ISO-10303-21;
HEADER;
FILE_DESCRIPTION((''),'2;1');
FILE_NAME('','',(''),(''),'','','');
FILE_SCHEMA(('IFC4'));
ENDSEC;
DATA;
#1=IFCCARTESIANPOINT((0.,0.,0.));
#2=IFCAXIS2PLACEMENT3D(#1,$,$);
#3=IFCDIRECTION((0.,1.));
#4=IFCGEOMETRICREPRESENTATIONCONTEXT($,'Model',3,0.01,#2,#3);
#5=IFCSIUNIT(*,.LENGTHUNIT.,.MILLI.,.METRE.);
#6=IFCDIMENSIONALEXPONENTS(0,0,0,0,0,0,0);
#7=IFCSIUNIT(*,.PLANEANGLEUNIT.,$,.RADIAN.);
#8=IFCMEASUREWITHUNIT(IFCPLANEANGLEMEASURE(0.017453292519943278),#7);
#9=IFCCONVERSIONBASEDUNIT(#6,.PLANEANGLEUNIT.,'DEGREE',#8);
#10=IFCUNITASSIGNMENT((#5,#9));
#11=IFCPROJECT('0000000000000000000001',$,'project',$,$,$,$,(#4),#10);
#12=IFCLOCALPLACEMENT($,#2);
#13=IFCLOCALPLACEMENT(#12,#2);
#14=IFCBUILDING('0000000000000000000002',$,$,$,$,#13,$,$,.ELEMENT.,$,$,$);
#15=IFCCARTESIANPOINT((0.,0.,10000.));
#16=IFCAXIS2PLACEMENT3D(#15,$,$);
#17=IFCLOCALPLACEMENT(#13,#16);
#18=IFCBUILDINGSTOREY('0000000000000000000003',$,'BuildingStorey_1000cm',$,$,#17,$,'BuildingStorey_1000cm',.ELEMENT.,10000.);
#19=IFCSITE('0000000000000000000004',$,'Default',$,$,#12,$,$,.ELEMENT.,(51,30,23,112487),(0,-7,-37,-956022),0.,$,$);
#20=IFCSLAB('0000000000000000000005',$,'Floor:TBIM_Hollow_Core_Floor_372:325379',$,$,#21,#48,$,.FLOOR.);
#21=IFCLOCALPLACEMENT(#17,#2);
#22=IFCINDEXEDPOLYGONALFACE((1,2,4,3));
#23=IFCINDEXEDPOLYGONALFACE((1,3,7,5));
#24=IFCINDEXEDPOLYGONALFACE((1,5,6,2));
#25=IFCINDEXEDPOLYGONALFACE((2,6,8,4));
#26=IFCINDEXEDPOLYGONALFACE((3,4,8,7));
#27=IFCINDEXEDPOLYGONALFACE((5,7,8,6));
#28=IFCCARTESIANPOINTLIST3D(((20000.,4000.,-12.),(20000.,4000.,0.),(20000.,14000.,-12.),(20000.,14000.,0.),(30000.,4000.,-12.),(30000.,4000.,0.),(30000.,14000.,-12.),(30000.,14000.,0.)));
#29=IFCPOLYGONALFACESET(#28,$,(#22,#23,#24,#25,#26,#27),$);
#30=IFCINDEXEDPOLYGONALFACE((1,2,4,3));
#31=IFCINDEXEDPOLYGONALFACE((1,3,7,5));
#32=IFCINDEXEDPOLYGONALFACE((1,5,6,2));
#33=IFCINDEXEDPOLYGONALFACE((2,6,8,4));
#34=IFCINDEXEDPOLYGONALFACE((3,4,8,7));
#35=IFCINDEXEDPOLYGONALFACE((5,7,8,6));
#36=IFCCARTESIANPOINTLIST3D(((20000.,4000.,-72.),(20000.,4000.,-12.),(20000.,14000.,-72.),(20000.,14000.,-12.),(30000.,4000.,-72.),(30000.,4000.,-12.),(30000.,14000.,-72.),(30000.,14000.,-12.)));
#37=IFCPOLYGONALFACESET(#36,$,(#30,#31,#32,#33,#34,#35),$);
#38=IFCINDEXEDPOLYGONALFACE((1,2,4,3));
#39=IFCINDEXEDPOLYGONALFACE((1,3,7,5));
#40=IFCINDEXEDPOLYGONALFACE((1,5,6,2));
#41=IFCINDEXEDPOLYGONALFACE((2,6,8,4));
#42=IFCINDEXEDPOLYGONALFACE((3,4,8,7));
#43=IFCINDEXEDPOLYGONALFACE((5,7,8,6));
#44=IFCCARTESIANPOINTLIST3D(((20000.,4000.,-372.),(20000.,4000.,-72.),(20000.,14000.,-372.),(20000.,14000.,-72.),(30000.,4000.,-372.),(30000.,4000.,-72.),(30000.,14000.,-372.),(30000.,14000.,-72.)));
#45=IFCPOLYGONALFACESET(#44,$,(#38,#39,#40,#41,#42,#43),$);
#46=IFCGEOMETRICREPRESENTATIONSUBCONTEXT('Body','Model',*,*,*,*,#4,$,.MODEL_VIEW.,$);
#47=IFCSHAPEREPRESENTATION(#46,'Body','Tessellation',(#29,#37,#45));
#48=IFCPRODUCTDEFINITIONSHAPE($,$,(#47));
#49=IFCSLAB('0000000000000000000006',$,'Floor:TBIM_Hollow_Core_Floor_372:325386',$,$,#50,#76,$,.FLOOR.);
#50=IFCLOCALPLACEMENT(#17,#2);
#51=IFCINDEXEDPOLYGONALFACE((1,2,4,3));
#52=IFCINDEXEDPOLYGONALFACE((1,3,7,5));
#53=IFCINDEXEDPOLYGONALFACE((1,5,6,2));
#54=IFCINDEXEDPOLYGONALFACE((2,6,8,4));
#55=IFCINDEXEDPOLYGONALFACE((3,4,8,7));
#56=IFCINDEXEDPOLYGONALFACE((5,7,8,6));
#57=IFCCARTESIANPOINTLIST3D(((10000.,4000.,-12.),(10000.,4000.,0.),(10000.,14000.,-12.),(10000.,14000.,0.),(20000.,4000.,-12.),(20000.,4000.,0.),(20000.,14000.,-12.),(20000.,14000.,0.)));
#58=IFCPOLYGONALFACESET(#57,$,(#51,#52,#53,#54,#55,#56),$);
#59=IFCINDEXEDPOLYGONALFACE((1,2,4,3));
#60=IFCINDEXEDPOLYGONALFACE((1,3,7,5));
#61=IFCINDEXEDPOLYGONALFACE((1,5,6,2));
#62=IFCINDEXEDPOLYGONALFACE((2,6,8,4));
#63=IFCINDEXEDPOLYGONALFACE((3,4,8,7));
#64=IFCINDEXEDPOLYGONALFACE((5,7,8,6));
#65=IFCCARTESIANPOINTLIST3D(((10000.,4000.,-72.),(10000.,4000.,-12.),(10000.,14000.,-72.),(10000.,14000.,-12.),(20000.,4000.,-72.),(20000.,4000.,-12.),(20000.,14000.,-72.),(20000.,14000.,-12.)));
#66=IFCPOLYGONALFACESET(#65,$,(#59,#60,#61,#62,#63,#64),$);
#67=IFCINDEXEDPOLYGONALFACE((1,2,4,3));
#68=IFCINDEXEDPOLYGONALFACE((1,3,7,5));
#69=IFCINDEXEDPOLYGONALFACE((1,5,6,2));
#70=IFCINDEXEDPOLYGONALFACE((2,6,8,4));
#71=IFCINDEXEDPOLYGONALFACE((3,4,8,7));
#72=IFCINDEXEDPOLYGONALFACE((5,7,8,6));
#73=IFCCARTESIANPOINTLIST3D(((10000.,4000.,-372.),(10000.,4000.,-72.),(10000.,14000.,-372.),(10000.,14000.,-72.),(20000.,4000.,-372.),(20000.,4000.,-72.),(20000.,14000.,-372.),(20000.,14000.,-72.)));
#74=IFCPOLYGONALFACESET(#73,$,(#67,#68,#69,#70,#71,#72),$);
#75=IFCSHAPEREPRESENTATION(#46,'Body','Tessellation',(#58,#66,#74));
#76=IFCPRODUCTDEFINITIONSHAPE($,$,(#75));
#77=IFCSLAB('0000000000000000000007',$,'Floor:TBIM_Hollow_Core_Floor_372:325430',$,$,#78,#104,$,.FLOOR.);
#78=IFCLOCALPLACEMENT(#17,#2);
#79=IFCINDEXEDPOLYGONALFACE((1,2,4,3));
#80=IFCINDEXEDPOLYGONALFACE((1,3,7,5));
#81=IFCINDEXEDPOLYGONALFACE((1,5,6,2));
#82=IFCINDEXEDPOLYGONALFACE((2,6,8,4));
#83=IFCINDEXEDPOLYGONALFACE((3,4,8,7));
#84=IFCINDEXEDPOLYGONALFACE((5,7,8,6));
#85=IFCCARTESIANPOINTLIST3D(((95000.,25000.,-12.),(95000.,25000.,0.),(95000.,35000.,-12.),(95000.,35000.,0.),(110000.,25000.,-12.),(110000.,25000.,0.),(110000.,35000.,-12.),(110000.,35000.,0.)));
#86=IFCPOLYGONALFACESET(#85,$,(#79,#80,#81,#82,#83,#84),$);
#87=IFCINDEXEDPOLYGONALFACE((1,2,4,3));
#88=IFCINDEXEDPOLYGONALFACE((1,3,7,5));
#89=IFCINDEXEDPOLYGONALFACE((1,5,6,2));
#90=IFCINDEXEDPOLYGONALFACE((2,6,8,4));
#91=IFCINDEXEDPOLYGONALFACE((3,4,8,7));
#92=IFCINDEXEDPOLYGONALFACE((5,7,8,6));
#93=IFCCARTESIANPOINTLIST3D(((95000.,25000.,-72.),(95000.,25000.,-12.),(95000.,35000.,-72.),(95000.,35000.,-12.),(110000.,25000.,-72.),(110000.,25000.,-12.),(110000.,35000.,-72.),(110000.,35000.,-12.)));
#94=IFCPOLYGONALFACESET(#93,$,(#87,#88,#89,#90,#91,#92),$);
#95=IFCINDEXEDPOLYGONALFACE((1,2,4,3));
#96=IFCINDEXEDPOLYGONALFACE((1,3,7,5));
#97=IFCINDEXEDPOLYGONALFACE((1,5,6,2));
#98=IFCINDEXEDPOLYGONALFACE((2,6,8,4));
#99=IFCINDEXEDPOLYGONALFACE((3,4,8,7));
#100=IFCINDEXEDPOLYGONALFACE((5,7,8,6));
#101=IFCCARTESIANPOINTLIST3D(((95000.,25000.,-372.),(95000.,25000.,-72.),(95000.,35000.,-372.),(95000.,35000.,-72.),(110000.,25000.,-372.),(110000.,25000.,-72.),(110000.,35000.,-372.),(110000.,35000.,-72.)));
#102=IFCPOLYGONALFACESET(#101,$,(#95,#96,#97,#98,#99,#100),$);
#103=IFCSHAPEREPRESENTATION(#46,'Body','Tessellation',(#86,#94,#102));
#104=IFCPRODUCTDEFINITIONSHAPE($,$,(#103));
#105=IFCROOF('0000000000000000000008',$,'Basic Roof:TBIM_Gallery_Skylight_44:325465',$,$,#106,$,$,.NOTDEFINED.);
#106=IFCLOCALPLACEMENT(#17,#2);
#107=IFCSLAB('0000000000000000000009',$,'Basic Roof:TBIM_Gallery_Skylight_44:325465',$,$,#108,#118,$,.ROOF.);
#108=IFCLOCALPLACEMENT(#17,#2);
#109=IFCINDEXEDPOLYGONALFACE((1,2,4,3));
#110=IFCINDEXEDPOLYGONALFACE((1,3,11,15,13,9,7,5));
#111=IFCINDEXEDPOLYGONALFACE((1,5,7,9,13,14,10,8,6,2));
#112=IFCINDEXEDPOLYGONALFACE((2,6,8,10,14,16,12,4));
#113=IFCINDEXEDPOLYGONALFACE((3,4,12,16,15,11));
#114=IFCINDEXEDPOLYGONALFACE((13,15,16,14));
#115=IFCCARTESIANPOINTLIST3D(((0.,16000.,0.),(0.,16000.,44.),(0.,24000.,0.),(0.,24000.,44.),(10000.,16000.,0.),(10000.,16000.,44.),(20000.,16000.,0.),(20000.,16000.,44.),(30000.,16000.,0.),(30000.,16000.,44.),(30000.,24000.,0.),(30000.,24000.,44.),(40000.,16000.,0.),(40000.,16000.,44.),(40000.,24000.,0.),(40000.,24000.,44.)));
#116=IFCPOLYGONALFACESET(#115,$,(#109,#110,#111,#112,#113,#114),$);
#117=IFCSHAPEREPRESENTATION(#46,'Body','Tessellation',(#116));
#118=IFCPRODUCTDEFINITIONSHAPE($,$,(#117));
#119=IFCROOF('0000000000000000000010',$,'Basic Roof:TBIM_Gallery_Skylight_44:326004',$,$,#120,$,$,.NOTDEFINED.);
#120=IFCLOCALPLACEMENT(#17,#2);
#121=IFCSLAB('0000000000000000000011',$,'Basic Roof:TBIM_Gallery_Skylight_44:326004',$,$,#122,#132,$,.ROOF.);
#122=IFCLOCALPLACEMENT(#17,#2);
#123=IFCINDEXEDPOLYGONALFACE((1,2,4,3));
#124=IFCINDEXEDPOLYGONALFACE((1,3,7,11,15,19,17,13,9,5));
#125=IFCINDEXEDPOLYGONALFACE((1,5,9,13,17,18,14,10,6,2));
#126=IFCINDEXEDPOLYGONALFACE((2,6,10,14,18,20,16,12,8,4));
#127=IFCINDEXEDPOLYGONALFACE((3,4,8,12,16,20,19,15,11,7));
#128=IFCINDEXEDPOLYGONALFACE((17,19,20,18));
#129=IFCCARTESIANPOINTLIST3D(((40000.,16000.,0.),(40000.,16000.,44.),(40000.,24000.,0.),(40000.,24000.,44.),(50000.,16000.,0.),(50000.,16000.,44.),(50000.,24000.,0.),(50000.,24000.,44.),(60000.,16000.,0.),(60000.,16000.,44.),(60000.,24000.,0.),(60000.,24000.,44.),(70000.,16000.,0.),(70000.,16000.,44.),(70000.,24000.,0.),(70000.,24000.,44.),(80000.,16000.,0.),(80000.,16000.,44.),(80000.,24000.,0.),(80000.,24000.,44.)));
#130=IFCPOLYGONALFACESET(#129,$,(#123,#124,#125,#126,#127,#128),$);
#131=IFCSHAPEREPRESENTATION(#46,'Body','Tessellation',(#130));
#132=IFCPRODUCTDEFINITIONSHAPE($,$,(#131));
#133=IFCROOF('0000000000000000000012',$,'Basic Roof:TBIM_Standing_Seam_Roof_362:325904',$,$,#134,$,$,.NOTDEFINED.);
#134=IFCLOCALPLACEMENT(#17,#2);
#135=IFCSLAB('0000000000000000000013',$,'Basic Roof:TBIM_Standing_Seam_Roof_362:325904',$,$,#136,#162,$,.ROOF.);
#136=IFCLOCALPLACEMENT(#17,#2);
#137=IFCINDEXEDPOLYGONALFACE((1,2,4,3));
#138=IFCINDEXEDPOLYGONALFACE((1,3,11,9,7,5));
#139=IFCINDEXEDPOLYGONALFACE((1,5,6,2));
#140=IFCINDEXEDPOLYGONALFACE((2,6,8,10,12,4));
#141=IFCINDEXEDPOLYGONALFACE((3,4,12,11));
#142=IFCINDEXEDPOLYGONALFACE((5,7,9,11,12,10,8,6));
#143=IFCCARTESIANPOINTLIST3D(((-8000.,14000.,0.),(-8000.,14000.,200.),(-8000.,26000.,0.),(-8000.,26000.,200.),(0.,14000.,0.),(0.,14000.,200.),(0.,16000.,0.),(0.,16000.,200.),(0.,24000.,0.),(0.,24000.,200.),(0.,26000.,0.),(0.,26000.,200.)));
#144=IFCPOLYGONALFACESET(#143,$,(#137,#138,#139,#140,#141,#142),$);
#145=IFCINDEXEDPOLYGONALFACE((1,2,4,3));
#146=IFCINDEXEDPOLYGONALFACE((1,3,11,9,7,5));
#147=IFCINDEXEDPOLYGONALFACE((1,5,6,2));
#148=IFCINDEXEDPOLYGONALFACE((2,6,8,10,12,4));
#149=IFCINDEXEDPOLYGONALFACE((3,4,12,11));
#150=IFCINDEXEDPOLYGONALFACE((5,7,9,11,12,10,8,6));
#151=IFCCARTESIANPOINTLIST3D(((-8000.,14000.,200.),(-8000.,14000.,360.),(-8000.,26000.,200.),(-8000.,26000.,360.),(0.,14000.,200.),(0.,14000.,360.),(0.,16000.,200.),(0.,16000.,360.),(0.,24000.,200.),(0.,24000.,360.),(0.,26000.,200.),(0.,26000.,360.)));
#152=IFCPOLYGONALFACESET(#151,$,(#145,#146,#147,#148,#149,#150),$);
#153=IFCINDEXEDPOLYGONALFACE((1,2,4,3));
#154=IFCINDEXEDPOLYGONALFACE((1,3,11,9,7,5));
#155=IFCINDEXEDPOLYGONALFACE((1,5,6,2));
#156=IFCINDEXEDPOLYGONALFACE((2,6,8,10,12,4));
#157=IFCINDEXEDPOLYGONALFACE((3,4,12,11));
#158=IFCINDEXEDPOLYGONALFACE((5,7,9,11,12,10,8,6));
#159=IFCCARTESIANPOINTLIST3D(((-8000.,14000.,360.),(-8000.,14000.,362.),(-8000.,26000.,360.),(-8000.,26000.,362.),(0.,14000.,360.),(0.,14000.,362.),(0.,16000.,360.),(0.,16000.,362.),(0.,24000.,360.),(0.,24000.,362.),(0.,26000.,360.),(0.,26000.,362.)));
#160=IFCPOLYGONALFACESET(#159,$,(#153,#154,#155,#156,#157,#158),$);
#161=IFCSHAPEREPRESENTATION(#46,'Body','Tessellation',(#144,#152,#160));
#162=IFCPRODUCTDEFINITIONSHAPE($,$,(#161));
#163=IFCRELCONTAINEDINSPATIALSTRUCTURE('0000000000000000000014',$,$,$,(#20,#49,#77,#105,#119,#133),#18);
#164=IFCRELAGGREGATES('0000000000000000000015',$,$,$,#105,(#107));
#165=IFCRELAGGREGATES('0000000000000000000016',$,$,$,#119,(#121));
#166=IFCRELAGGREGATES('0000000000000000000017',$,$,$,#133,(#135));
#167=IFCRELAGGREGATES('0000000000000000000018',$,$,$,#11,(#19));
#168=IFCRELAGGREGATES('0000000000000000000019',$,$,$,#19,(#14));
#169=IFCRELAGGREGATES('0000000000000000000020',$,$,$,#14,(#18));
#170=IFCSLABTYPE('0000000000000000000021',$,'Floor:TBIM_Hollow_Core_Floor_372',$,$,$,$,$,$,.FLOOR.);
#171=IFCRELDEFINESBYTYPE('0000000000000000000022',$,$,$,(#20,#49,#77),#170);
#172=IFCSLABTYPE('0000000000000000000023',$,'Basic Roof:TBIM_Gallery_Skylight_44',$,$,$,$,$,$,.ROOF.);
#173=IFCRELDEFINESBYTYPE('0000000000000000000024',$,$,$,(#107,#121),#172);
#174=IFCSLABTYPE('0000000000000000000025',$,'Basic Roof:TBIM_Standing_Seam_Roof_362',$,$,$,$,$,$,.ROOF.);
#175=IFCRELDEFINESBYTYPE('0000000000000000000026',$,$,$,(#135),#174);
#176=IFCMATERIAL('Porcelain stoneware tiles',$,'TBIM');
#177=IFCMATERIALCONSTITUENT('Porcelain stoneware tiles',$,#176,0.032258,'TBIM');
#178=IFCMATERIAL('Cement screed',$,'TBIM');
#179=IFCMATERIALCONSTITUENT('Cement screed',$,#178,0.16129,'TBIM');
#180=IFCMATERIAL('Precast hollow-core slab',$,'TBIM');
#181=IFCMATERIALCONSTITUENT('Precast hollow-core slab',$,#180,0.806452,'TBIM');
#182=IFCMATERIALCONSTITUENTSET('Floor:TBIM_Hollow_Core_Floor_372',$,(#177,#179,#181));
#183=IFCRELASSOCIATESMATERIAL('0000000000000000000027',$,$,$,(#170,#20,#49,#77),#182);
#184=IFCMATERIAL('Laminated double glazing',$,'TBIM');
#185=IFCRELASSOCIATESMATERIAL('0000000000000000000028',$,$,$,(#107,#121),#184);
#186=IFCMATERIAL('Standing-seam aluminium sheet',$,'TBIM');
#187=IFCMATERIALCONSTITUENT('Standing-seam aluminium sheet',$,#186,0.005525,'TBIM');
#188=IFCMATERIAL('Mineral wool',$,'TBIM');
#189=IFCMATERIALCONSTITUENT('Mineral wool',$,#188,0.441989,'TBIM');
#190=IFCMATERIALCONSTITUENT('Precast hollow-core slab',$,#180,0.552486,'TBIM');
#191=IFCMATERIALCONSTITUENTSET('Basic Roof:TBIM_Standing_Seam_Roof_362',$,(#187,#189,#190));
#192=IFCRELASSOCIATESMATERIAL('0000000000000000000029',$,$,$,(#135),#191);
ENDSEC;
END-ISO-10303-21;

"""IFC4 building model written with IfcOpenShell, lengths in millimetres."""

from ifc_helpers import new_model, entity, si_unit, converted_unit, direction, frame, origin, place, context, subcontext, project, spatial, indexed_curve, outline, extrude, material, constituent, constituent_set, type_object, element, aggregate, save


model = new_model("IFC4")

# Units and contexts
model_context = context("Model", 3, precision=0.01, world=origin(), true_north=direction((0.0, 1.0)))
body_context = subcontext(model_context, "Body", "Model", "MODEL_VIEW")
ifc_project = project(units=[si_unit("LENGTHUNIT", "METRE", prefix="MILLI"), converted_unit("PLANEANGLEUNIT", "DEGREE", entity("IfcPlaneAngleMeasure", 0.017453292519943278), si_unit("PLANEANGLEUNIT", "RADIAN"), dimensions=[0, 0, 0, 0, 0, 0, 0])], contexts=[model_context])

# Site, building, storey
site_placement = place(None, origin())
site = spatial("IfcSite", under=ifc_project, at=site_placement, Name="Default", CompositionType="ELEMENT", RefLatitude=(51, 30, 23, 112487), RefLongitude=(0, -7, -37, -956022), RefElevation=0.0)
building_placement = place(site_placement, origin())
building = spatial("IfcBuilding", under=site, at=building_placement, CompositionType="ELEMENT")
storey_placement = place(building_placement, frame((0.0, 0.0, 10000.0)))
storey = spatial("IfcBuildingStorey", under=building, at=storey_placement, Name="BuildingStorey_1000cm", LongName="BuildingStorey_1000cm", CompositionType="ELEMENT", Elevation=10000.0)

# Slabs
ifc_material_1 = material(Name="Porcelain stoneware tiles", Category="TBIM")
ifc_constituent_1 = constituent(ifc_material_1, Name="Porcelain stoneware tiles", Category="TBIM", fraction=0.032258)
ifc_material_2 = material(Name="Cement screed", Category="TBIM")
ifc_constituent_2 = constituent(ifc_material_2, Name="Cement screed", Category="TBIM", fraction=0.16129)
ifc_material_3 = material(Name="Precast hollow-core slab", Category="TBIM")
ifc_constituent_3 = constituent(ifc_material_3, Name="Precast hollow-core slab", Category="TBIM", fraction=0.806452)
ifc_constituent_set_1 = constituent_set(constituents=[ifc_constituent_1, ifc_constituent_2, ifc_constituent_3], Name="Floor:TBIM_Hollow_Core_Floor_372")
slab_type_1 = type_object("IfcSlabType", Name="Floor:TBIM_Hollow_Core_Floor_372", PredefinedType="FLOOR", material=ifc_constituent_set_1)
slab_1_placement = place(storey_placement, origin())
element("IfcSlab", 1, at=slab_1_placement, inside=storey, type_object=slab_type_1, material=ifc_constituent_set_1, Name="Floor:TBIM_Hollow_Core_Floor_372:325379", PredefinedType="FLOOR", context=body_context, shape_type="SweptSolid", body=[
    extrude(outline(indexed_curve([(-5000.0, -5000.0), (5000.0, -5000.0), (5000.0, 5000.0), (-5000.0, 5000.0), (-5000.0, -5000.0)], self_intersect=False)), frame((25000.0, 9000.0, -12.0), z_axis=(0.0, 0.0, 1.0), x_axis=(-1.0, 0.0, 0.0)), (0.0, 0.0, 1.0), 12.0),
    extrude(outline(indexed_curve([(-5000.0, -5000.0), (5000.0, -5000.0), (5000.0, 5000.0), (-5000.0, 5000.0), (-5000.0, -5000.0)], self_intersect=False)), frame((25000.0, 9000.0, -72.0), z_axis=(0.0, 0.0, 1.0), x_axis=(-1.0, 0.0, 0.0)), (0.0, 0.0, 1.0), 60.0),
    extrude(outline(indexed_curve([(-5000.0, -5000.0), (5000.0, -5000.0), (5000.0, 5000.0), (-5000.0, 5000.0), (-5000.0, -5000.0)], self_intersect=False)), frame((25000.0, 9000.0, -372.0), z_axis=(0.0, 0.0, 1.0), x_axis=(-1.0, 0.0, 0.0)), (0.0, 0.0, 1.0), 300.0),
])
slab_2_placement = place(storey_placement, origin())
element("IfcSlab", 2, at=slab_2_placement, inside=storey, type_object=slab_type_1, material=ifc_constituent_set_1, Name="Floor:TBIM_Hollow_Core_Floor_372:325386", PredefinedType="FLOOR", context=body_context, shape_type="SweptSolid", body=[
    extrude(outline(indexed_curve([(-5000.0, -5000.0), (5000.0, -5000.0), (5000.0, 5000.0), (-5000.0, 5000.0), (-5000.0, -5000.0)], self_intersect=False)), frame((15000.0, 9000.0, -12.0), z_axis=(0.0, 0.0, 1.0), x_axis=(0.0, -1.0, 0.0)), (0.0, 0.0, 1.0), 12.0),
    extrude(outline(indexed_curve([(-5000.0, -5000.0), (5000.0, -5000.0), (5000.0, 5000.0), (-5000.0, 5000.0), (-5000.0, -5000.0)], self_intersect=False)), frame((15000.0, 9000.0, -72.0), z_axis=(0.0, 0.0, 1.0), x_axis=(0.0, -1.0, 0.0)), (0.0, 0.0, 1.0), 60.0),
    extrude(outline(indexed_curve([(-5000.0, -5000.0), (5000.0, -5000.0), (5000.0, 5000.0), (-5000.0, 5000.0), (-5000.0, -5000.0)], self_intersect=False)), frame((15000.0, 9000.0, -372.0), z_axis=(0.0, 0.0, 1.0), x_axis=(0.0, -1.0, 0.0)), (0.0, 0.0, 1.0), 300.0),
])
slab_3_placement = place(storey_placement, origin())
element("IfcSlab", 3, at=slab_3_placement, inside=storey, type_object=slab_type_1, material=ifc_constituent_set_1, Name="Floor:TBIM_Hollow_Core_Floor_372:325430", PredefinedType="FLOOR", context=body_context, shape_type="SweptSolid", body=[
    extrude(outline(indexed_curve([(-7500.0, -5000.0), (7500.0, -5000.0), (7500.0, 5000.0), (-7500.0, 5000.0), (-7500.0, -5000.0)], self_intersect=False)), frame((102500.0, 30000.0, -12.0), z_axis=(0.0, 0.0, 1.0), x_axis=(-1.0, 0.0, 0.0)), (0.0, 0.0, 1.0), 12.0),
    extrude(outline(indexed_curve([(-7500.0, -5000.0), (7500.0, -5000.0), (7500.0, 5000.0), (-7500.0, 5000.0), (-7500.0, -5000.0)], self_intersect=False)), frame((102500.0, 30000.0, -72.0), z_axis=(0.0, 0.0, 1.0), x_axis=(-1.0, 0.0, 0.0)), (0.0, 0.0, 1.0), 60.0),
    extrude(outline(indexed_curve([(-7500.0, -5000.0), (7500.0, -5000.0), (7500.0, 5000.0), (-7500.0, 5000.0), (-7500.0, -5000.0)], self_intersect=False)), frame((102500.0, 30000.0, -372.0), z_axis=(0.0, 0.0, 1.0), x_axis=(-1.0, 0.0, 0.0)), (0.0, 0.0, 1.0), 300.0),
])

# Roofs, slabs
roof_1_placement = place(storey_placement, frame((0.0, 16000.0, 0.0)))
roof_1 = element("IfcRoof", 4, at=roof_1_placement, inside=storey, Name="Basic Roof:TBIM_Gallery_Skylight_44:325465", PredefinedType="NOTDEFINED")
ifc_material_4 = material(Name="Laminated double glazing", Category="TBIM")
slab_type_2 = type_object("IfcSlabType", Name="Basic Roof:TBIM_Gallery_Skylight_44", PredefinedType="ROOF")
slab_4_placement = place(roof_1_placement, origin())
slab_4 = element("IfcSlab", 5, at=slab_4_placement, type_object=slab_type_2, material=ifc_material_4, Name="Basic Roof:TBIM_Gallery_Skylight_44:325465", PredefinedType="ROOF", context=body_context, shape_type="SweptSolid", body=[
    extrude(outline(indexed_curve([(10000.0, 4000.0), (-20000.0, 4000.0), (-20000.0, -4000.0), (-10000.0, -4000.0), (0.0, -4000.0), (10000.0, -4000.0), (20000.0, -4000.0), (20000.0, 4000.0), (10000.0, 4000.0)], self_intersect=False)), frame((20000.0, 4000.0, 0.0)), (0.0, 0.0, 1.0), 44.0),
])
aggregate(roof_1, [slab_4])
roof_2_placement = place(storey_placement, frame((40000.0, 16000.0, 0.0)))
roof_2 = element("IfcRoof", 6, at=roof_2_placement, inside=storey, Name="Basic Roof:TBIM_Gallery_Skylight_44:326004", PredefinedType="NOTDEFINED")
slab_5_placement = place(roof_2_placement, origin())
slab_5 = element("IfcSlab", 7, at=slab_5_placement, type_object=slab_type_2, material=ifc_material_4, Name="Basic Roof:TBIM_Gallery_Skylight_44:326004", PredefinedType="ROOF", context=body_context, shape_type="SweptSolid", body=[
    extrude(outline(indexed_curve([(-10000.0, 4000.0), (-20000.0, 4000.0), (-20000.0, -4000.0), (-10000.0, -4000.0), (0.0, -4000.0), (10000.0, -4000.0), (20000.0, -4000.0), (20000.0, 4000.0), (10000.0, 4000.0), (0.0, 4000.0), (-10000.0, 4000.0)], self_intersect=False)), frame((20000.0, 4000.0, 0.0)), (0.0, 0.0, 1.0), 44.0),
])
aggregate(roof_2, [slab_5])
roof_3_placement = place(storey_placement, frame((-8000.0, 14000.0, 0.0)))
roof_3 = element("IfcRoof", 8, at=roof_3_placement, inside=storey, Name="Basic Roof:TBIM_Standing_Seam_Roof_362:325904", PredefinedType="NOTDEFINED")
ifc_material_5 = material(Name="Standing-seam aluminium sheet", Category="TBIM")
ifc_constituent_4 = constituent(ifc_material_5, Name="Standing-seam aluminium sheet", Category="TBIM", fraction=0.005525)
ifc_material_6 = material(Name="Mineral wool", Category="TBIM")
ifc_constituent_5 = constituent(ifc_material_6, Name="Mineral wool", Category="TBIM", fraction=0.441989)
ifc_constituent_6 = constituent(ifc_material_3, Name="Precast hollow-core slab", Category="TBIM", fraction=0.552486)
ifc_constituent_set_2 = constituent_set(constituents=[ifc_constituent_4, ifc_constituent_5, ifc_constituent_6], Name="Basic Roof:TBIM_Standing_Seam_Roof_362")
slab_type_3 = type_object("IfcSlabType", Name="Basic Roof:TBIM_Standing_Seam_Roof_362", PredefinedType="ROOF")
slab_6_placement = place(roof_3_placement, origin())
slab_6 = element("IfcSlab", 9, at=slab_6_placement, type_object=slab_type_3, material=ifc_constituent_set_2, Name="Basic Roof:TBIM_Standing_Seam_Roof_362:325904", PredefinedType="ROOF", context=body_context, shape_type="SweptSolid", body=[
    extrude(outline(indexed_curve([(-4000.0, 6000.0), (-4000.0, -6000.0), (4000.0, -6000.0), (4000.0, -4000.0), (4000.0, 4000.0), (4000.0, 6000.0), (-4000.0, 6000.0)], self_intersect=False)), frame((4000.0, 6000.0, 0.0)), (0.0, 0.0, 1.0), 200.0),
    extrude(outline(indexed_curve([(-4000.0, 6000.0), (-4000.0, -6000.0), (4000.0, -6000.0), (4000.0, -4000.0), (4000.0, 4000.0), (4000.0, 6000.0), (-4000.0, 6000.0)], self_intersect=False)), frame((4000.0, 6000.0, 200.0)), (0.0, 0.0, 1.0), 160.0),
    extrude(outline(indexed_curve([(-4000.0, 6000.0), (-4000.0, -6000.0), (4000.0, -6000.0), (4000.0, -4000.0), (4000.0, 4000.0), (4000.0, 6000.0), (-4000.0, 6000.0)], self_intersect=False)), frame((4000.0, 6000.0, 360.0)), (0.0, 0.0, 1.0), 2.0),
])
aggregate(roof_3, [slab_6])

save(model, "model.ifc")
